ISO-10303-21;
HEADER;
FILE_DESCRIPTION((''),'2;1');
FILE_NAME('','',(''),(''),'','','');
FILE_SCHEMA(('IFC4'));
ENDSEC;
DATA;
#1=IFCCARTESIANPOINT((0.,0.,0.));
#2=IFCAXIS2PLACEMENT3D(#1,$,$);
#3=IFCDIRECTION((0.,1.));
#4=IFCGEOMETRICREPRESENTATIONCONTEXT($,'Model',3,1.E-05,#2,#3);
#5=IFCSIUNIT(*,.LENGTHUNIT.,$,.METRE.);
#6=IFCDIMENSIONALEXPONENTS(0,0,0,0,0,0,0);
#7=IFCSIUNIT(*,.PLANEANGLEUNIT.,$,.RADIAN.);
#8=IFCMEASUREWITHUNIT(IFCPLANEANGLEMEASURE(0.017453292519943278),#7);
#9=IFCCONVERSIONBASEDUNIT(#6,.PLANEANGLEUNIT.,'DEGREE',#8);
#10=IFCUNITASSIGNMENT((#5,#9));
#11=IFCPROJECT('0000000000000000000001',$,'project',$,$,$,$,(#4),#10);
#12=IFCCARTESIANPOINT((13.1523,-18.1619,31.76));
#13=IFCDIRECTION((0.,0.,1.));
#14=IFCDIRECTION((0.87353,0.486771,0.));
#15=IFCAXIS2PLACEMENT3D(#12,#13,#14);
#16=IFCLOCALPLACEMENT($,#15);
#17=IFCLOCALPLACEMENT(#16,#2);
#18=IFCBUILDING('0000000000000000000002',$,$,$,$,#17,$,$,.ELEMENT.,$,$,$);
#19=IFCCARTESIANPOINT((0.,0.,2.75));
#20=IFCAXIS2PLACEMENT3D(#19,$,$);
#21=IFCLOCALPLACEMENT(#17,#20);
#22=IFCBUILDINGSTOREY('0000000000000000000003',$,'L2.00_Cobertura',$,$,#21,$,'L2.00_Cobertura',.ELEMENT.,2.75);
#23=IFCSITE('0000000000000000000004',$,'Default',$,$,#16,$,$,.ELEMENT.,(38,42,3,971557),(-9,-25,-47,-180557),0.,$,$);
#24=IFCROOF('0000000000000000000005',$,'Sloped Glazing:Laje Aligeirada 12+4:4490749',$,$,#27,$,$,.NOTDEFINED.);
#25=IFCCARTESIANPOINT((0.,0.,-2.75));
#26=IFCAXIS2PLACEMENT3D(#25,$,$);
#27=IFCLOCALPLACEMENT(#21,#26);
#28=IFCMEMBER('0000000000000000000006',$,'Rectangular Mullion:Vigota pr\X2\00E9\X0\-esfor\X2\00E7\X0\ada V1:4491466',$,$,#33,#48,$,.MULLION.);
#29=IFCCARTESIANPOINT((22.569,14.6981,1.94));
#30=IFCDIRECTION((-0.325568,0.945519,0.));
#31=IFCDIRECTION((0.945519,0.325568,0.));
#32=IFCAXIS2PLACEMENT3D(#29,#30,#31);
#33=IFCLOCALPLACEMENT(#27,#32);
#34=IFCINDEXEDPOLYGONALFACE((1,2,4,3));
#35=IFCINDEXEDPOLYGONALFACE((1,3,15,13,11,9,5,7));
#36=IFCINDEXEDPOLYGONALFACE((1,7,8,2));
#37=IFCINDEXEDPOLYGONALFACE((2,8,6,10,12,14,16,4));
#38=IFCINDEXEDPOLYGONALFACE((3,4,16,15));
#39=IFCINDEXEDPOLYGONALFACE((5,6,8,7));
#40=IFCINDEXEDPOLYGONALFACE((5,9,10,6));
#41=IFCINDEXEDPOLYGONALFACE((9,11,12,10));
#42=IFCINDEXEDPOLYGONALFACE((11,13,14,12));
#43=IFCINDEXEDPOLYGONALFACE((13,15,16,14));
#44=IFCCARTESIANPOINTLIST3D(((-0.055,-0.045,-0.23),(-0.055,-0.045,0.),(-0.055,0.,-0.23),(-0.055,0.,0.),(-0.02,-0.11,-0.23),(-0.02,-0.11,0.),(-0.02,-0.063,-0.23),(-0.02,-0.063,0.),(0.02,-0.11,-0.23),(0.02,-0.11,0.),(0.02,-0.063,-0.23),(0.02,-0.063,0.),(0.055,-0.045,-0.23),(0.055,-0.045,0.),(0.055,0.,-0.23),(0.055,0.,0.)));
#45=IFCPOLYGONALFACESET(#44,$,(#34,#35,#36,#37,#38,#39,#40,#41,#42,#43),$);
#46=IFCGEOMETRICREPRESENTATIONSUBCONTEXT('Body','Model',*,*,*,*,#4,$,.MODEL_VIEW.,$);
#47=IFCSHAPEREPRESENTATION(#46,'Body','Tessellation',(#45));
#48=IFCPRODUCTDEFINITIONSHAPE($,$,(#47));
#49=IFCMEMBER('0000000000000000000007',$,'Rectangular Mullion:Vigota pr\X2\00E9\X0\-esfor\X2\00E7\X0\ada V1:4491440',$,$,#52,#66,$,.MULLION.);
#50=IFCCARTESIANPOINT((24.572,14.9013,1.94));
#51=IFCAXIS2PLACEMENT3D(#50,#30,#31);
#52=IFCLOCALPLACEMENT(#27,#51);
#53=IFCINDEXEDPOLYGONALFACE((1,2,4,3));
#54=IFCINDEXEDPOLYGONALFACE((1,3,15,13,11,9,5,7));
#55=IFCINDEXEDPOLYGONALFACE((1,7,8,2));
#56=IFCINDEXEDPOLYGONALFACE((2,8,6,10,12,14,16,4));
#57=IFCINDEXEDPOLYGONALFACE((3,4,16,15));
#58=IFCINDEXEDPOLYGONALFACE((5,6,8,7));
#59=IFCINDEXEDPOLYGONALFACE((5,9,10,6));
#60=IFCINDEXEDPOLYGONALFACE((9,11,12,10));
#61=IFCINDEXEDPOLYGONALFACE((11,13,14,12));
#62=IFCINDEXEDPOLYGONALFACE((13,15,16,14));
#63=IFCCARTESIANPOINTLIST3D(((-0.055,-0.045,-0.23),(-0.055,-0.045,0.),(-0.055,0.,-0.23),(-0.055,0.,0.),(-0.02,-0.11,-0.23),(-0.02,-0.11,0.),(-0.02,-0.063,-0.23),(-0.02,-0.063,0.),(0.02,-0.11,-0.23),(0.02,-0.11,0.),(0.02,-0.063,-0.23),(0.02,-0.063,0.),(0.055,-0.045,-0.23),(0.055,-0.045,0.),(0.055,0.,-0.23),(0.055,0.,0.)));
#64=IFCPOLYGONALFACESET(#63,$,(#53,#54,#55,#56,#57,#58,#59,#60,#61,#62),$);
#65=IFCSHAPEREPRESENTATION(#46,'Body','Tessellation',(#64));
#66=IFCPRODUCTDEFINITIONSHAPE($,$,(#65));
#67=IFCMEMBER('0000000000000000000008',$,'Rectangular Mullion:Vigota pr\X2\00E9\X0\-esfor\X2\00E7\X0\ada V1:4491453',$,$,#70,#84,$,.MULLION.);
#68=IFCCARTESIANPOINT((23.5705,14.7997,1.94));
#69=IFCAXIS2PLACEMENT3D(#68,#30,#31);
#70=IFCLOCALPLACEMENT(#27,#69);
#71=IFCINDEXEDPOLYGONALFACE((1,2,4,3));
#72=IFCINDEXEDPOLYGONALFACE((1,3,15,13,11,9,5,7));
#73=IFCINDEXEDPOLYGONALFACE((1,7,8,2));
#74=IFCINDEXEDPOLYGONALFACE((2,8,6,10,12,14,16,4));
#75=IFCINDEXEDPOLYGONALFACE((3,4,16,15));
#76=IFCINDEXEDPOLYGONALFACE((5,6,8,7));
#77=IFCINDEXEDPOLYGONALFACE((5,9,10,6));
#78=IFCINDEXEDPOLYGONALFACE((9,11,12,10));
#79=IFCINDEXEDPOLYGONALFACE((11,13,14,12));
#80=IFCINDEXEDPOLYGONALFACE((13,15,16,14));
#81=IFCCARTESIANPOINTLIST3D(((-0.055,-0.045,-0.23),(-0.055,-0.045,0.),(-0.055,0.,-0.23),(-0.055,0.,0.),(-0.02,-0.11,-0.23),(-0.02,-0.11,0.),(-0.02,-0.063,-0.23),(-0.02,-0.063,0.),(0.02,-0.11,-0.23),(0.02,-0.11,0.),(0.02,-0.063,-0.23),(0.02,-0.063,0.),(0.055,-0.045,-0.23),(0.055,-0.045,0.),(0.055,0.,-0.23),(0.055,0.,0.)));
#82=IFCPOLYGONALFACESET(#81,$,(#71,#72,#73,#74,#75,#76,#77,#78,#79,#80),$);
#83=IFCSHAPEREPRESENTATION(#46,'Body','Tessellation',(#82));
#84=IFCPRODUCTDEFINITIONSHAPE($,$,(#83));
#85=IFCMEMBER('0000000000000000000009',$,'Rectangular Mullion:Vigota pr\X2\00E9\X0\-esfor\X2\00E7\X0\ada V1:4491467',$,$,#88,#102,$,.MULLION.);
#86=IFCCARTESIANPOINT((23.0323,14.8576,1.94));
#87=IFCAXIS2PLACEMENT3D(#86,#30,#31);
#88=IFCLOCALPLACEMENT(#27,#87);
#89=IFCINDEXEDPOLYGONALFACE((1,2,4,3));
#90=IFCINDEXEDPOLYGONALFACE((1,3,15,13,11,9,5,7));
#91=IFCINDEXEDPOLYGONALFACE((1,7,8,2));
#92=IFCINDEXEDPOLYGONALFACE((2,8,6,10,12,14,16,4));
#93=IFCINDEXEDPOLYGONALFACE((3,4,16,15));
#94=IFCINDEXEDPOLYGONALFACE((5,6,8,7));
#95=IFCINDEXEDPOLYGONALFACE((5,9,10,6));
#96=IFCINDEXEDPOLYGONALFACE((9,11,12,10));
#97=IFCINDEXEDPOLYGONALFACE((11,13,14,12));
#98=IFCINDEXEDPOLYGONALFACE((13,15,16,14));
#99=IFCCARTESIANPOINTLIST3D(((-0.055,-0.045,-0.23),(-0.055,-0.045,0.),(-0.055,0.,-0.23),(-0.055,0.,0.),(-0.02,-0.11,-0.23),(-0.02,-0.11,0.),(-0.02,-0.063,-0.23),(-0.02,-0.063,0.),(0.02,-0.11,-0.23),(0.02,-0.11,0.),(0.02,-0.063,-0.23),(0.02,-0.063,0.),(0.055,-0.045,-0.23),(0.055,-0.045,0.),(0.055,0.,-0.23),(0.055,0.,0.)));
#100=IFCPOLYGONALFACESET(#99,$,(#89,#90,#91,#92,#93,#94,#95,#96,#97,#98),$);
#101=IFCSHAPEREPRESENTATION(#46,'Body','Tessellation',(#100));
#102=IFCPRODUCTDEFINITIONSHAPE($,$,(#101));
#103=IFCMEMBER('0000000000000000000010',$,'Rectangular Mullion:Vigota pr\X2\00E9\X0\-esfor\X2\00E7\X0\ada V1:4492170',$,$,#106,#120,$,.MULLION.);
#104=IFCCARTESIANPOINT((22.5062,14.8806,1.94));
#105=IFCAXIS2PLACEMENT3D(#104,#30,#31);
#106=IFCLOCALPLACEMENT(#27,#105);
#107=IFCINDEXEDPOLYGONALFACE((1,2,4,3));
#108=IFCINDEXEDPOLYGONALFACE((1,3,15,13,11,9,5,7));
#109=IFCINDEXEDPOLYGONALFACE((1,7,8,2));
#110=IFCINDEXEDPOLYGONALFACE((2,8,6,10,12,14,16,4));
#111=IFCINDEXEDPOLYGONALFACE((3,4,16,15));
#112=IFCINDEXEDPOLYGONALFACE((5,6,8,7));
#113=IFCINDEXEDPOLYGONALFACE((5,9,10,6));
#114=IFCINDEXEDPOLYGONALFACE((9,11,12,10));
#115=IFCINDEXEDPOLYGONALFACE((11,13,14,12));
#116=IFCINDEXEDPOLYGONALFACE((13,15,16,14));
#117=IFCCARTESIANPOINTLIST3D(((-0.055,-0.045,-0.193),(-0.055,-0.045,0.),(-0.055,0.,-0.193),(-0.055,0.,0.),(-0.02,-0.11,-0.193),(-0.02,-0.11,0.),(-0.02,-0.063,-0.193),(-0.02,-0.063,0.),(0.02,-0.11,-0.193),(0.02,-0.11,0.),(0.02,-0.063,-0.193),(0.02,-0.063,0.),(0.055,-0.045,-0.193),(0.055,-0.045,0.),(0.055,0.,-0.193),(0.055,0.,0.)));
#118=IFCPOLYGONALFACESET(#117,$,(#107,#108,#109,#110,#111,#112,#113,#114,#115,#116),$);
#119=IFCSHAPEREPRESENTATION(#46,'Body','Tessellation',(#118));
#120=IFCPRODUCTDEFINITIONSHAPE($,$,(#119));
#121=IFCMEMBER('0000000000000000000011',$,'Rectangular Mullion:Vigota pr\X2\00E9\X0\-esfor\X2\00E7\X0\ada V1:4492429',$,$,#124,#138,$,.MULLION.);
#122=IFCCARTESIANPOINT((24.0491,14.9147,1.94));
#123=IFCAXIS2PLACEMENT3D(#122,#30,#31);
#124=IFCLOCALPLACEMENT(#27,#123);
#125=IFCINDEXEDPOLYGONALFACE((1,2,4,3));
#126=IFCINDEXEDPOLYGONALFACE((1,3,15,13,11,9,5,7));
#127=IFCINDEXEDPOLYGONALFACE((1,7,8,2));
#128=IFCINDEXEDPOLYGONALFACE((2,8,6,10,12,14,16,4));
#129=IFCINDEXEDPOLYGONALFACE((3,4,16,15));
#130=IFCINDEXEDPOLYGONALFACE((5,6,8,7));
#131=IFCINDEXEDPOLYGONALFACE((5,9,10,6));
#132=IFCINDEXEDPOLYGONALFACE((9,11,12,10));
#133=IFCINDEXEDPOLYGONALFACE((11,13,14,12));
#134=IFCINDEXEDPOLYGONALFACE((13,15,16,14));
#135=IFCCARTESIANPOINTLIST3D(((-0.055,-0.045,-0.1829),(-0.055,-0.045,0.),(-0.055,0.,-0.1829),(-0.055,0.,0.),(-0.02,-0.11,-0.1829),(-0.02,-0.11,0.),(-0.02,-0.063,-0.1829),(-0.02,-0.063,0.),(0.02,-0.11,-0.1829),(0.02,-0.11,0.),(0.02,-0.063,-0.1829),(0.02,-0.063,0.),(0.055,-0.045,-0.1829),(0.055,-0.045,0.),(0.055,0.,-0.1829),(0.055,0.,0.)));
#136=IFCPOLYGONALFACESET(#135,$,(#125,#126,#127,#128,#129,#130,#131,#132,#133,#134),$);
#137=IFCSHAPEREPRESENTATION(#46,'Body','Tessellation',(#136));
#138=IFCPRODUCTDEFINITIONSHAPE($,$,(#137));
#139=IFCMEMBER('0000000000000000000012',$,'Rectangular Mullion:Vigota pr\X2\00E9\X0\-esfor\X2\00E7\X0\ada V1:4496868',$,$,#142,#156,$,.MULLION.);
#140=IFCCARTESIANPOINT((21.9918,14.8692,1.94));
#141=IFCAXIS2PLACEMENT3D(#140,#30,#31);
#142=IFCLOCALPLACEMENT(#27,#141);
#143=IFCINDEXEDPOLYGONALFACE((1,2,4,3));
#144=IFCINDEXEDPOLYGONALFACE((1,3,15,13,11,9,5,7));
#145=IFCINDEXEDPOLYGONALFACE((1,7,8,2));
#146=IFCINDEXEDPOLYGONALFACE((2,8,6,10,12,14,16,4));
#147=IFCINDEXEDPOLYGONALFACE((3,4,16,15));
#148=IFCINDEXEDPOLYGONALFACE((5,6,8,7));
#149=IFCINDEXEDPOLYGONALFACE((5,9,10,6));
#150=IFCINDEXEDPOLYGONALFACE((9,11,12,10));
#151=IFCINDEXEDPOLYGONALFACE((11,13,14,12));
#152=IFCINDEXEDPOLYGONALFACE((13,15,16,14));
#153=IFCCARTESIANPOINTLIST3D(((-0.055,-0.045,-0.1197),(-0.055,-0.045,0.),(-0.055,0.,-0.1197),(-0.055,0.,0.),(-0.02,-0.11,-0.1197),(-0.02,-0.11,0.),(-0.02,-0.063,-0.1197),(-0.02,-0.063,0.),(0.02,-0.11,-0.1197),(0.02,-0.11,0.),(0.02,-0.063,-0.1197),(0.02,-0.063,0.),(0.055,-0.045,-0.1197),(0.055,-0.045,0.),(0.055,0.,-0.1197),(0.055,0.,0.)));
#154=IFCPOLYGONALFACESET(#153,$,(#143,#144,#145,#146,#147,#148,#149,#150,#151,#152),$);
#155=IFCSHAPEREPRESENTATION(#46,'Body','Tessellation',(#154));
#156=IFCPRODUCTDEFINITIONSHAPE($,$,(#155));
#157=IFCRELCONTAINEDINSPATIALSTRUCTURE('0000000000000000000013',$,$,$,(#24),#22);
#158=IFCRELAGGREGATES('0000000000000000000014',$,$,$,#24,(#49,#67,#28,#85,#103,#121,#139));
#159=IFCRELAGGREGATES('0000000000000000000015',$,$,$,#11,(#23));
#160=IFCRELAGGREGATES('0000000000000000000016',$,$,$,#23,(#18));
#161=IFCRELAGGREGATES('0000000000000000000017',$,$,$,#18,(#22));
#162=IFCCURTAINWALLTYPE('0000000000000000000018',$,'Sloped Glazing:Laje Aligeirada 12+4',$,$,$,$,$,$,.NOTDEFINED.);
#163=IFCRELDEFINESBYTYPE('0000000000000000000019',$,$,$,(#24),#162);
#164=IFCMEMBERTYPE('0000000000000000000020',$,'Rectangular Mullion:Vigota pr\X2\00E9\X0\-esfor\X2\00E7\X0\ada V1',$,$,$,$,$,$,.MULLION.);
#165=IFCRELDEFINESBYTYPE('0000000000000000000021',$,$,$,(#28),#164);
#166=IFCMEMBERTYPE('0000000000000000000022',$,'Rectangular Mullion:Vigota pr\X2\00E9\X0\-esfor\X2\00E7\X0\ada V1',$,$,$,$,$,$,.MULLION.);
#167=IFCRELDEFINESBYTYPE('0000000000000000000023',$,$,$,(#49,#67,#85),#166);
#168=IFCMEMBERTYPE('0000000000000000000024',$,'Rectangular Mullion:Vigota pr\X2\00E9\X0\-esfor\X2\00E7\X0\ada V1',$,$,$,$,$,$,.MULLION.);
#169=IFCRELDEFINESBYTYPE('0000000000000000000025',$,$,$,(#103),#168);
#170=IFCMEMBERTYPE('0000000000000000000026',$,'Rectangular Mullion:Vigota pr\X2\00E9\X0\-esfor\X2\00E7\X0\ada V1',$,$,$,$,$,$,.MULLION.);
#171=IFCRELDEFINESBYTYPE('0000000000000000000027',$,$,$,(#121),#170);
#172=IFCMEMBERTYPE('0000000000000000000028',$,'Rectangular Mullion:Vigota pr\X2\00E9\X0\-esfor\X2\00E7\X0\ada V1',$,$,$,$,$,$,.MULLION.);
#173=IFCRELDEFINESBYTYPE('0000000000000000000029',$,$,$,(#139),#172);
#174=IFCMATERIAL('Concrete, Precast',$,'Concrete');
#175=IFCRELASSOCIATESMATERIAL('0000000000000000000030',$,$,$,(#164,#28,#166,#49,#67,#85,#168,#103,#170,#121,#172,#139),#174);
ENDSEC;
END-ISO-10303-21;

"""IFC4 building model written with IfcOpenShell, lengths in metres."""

from ifc_helpers import new_model, entity, si_unit, converted_unit, direction, frame, origin, place, context, subcontext, project, spatial, indexed_curve, outline, extrude, source, transform, mapped, material, type_object, type_shapes, element, aggregate, save


model = new_model("IFC4")

# Units and contexts
model_context = context("Model", 3, precision=1e-05, world=origin(), true_north=direction((0.0, 1.0)))
body_context = subcontext(model_context, "Body", "Model", "MODEL_VIEW")
ifc_project = project(units=[si_unit("LENGTHUNIT", "METRE"), converted_unit("PLANEANGLEUNIT", "DEGREE", entity("IfcPlaneAngleMeasure", 0.017453292519943278), si_unit("PLANEANGLEUNIT", "RADIAN"), dimensions=[0, 0, 0, 0, 0, 0, 0])], contexts=[model_context])

# Site, building, storey
site_placement = place(None, frame((13.1523, -18.1619, 31.76), z_axis=(0.0, 0.0, 1.0), x_axis=(0.87353, 0.486771, 0.0)))
site = spatial("IfcSite", under=ifc_project, at=site_placement, Name="Default", CompositionType="ELEMENT", RefLatitude=(38, 42, 3, 971557), RefLongitude=(-9, -25, -47, -180557), RefElevation=0.0)
building_placement = place(site_placement, origin())
building = spatial("IfcBuilding", under=site, at=building_placement, CompositionType="ELEMENT")
storey_placement = place(building_placement, frame((0.0, 0.0, 2.75)))
storey = spatial("IfcBuildingStorey", under=building, at=storey_placement, Name="L2.00_Cobertura", LongName="L2.00_Cobertura", CompositionType="ELEMENT", Elevation=2.75)

# Roof, members
curtain_wall_type = type_object("IfcCurtainWallType", Name="Sloped Glazing:Laje Aligeirada 12+4", PredefinedType="NOTDEFINED")
roof_placement = place(storey_placement, frame((0.0, 0.0, -2.75)))
roof = element("IfcRoof", 1, at=roof_placement, inside=storey, type_object=curtain_wall_type, Name="Sloped Glazing:Laje Aligeirada 12+4:4490749", PredefinedType="NOTDEFINED")
ifc_material_1 = material(Name="Concrete, Precast", Category="Concrete")
member_type_1 = type_object("IfcMemberType", Name="Rectangular Mullion:Vigota pré-esforçada V1", PredefinedType="MULLION", material=ifc_material_1)
shared_shape_1 = source(origin(), body_context, "Body", "SweptSolid", [
    extrude(outline(indexed_curve([(-0.055, -0.0545), (0.055, -0.0545), (0.055, -0.0095), (0.02, 0.0085), (0.02, 0.0555), (-0.02, 0.0555), (-0.02, 0.0085), (-0.055, -0.0095), (-0.055, -0.0545)], self_intersect=False)), frame((0.0, -0.0545, -0.23), z_axis=(0.0, 0.0, 1.0), x_axis=(-1.0, 0.0, 0.0)), (0.0, 0.0, 1.0), 0.23),
])
type_shapes(member_type_1, [shared_shape_1])
member_1_placement = place(roof_placement, frame((22.569, 14.6981, 1.94), z_axis=(-0.325568, 0.945519, 0.0), x_axis=(0.945519, 0.325568, 0.0)))
member_1 = element("IfcMember", 2, at=member_1_placement, type_object=member_type_1, material=ifc_material_1, Name="Rectangular Mullion:Vigota pré-esforçada V1:4491466", PredefinedType="MULLION", context=body_context, shape_type="MappedRepresentation", body=[
    mapped(shared_shape_1, transform((0.0, 0.0, 0.0), scale=1.0)),
])
member_type_2 = type_object("IfcMemberType", Name="Rectangular Mullion:Vigota pré-esforçada V1", PredefinedType="MULLION", material=ifc_material_1)
shared_shape_2 = source(origin(), body_context, "Body", "SweptSolid", [
    extrude(outline(indexed_curve([(-0.055, -0.0545), (0.055, -0.0545), (0.055, -0.0095), (0.02, 0.0085), (0.02, 0.0555), (-0.02, 0.0555), (-0.02, 0.0085), (-0.055, -0.0095), (-0.055, -0.0545)], self_intersect=False)), frame((0.0, -0.0545, -0.23), z_axis=(0.0, 0.0, 1.0), x_axis=(-1.0, 0.0, 0.0)), (0.0, 0.0, 1.0), 0.23),
])
type_shapes(member_type_2, [shared_shape_2])
member_2_placement = place(roof_placement, frame((24.572, 14.9013, 1.94), z_axis=(-0.325568, 0.945519, 0.0), x_axis=(0.945519, 0.325568, 0.0)))
member_2 = element("IfcMember", 3, at=member_2_placement, type_object=member_type_2, material=ifc_material_1, Name="Rectangular Mullion:Vigota pré-esforçada V1:4491440", PredefinedType="MULLION", context=body_context, shape_type="MappedRepresentation", body=[
    mapped(shared_shape_2, transform((0.0, 0.0, 0.0), scale=1.0)),
])
member_3_placement = place(roof_placement, frame((23.5705, 14.7997, 1.94), z_axis=(-0.325568, 0.945519, 0.0), x_axis=(0.945519, 0.325568, 0.0)))
member_3 = element("IfcMember", 4, at=member_3_placement, type_object=member_type_2, material=ifc_material_1, Name="Rectangular Mullion:Vigota pré-esforçada V1:4491453", PredefinedType="MULLION", context=body_context, shape_type="MappedRepresentation", body=[
    mapped(shared_shape_2, transform((0.0, 0.0, 0.0), scale=1.0)),
])
member_4_placement = place(roof_placement, frame((23.0323, 14.8576, 1.94), z_axis=(-0.325568, 0.945519, 0.0), x_axis=(0.945519, 0.325568, 0.0)))
member_4 = element("IfcMember", 5, at=member_4_placement, type_object=member_type_2, material=ifc_material_1, Name="Rectangular Mullion:Vigota pré-esforçada V1:4491467", PredefinedType="MULLION", context=body_context, shape_type="MappedRepresentation", body=[
    mapped(shared_shape_2, transform((0.0, 0.0, 0.0), scale=1.0)),
])
member_type_3 = type_object("IfcMemberType", Name="Rectangular Mullion:Vigota pré-esforçada V1", PredefinedType="MULLION", material=ifc_material_1)
shared_shape_3 = source(origin(), body_context, "Body", "SweptSolid", [
    extrude(outline(indexed_curve([(-0.055, -0.0545), (0.055, -0.0545), (0.055, -0.0095), (0.02, 0.0085), (0.02, 0.0555), (-0.02, 0.0555), (-0.02, 0.0085), (-0.055, -0.0095), (-0.055, -0.0545)], self_intersect=False)), frame((0.0, -0.0545, -0.193), z_axis=(0.0, 0.0, 1.0), x_axis=(-1.0, 0.0, 0.0)), (0.0, 0.0, 1.0), 0.193),
])
type_shapes(member_type_3, [shared_shape_3])
member_5_placement = place(roof_placement, frame((22.5062, 14.8806, 1.94), z_axis=(-0.325568, 0.945519, 0.0), x_axis=(0.945519, 0.325568, 0.0)))
member_5 = element("IfcMember", 6, at=member_5_placement, type_object=member_type_3, material=ifc_material_1, Name="Rectangular Mullion:Vigota pré-esforçada V1:4492170", PredefinedType="MULLION", context=body_context, shape_type="MappedRepresentation", body=[
    mapped(shared_shape_3, transform((0.0, 0.0, 0.0), scale=1.0)),
])
member_type_4 = type_object("IfcMemberType", Name="Rectangular Mullion:Vigota pré-esforçada V1", PredefinedType="MULLION", material=ifc_material_1)
shared_shape_4 = source(origin(), body_context, "Body", "SweptSolid", [
    extrude(outline(indexed_curve([(-0.055, -0.0545), (0.055, -0.0545), (0.055, -0.0095), (0.02, 0.0085), (0.02, 0.0555), (-0.02, 0.0555), (-0.02, 0.0085), (-0.055, -0.0095), (-0.055, -0.0545)], self_intersect=False)), frame((0.0, -0.0545, -0.1829), z_axis=(0.0, 0.0, 1.0), x_axis=(-1.0, 0.0, 0.0)), (0.0, 0.0, 1.0), 0.1829),
])
type_shapes(member_type_4, [shared_shape_4])
member_6_placement = place(roof_placement, frame((24.0491, 14.9147, 1.94), z_axis=(-0.325568, 0.945519, 0.0), x_axis=(0.945519, 0.325568, 0.0)))
member_6 = element("IfcMember", 7, at=member_6_placement, type_object=member_type_4, material=ifc_material_1, Name="Rectangular Mullion:Vigota pré-esforçada V1:4492429", PredefinedType="MULLION", context=body_context, shape_type="MappedRepresentation", body=[
    mapped(shared_shape_4, transform((0.0, 0.0, 0.0), scale=1.0)),
])
member_type_5 = type_object("IfcMemberType", Name="Rectangular Mullion:Vigota pré-esforçada V1", PredefinedType="MULLION", material=ifc_material_1)
shared_shape_5 = source(origin(), body_context, "Body", "SweptSolid", [
    extrude(outline(indexed_curve([(-0.055, -0.0545), (0.055, -0.0545), (0.055, -0.0095), (0.02, 0.0085), (0.02, 0.0555), (-0.02, 0.0555), (-0.02, 0.0085), (-0.055, -0.0095), (-0.055, -0.0545)], self_intersect=False)), frame((0.0, -0.0545, -0.1197), z_axis=(0.0, 0.0, 1.0), x_axis=(-1.0, 0.0, 0.0)), (0.0, 0.0, 1.0), 0.1197),
])
type_shapes(member_type_5, [shared_shape_5])
member_7_placement = place(roof_placement, frame((21.9918, 14.8692, 1.94), z_axis=(-0.325568, 0.945519, 0.0), x_axis=(0.945519, 0.325568, 0.0)))
member_7 = element("IfcMember", 8, at=member_7_placement, type_object=member_type_5, material=ifc_material_1, Name="Rectangular Mullion:Vigota pré-esforçada V1:4496868", PredefinedType="MULLION", context=body_context, shape_type="MappedRepresentation", body=[
    mapped(shared_shape_5, transform((0.0, 0.0, 0.0), scale=1.0)),
])
aggregate(roof, [member_2, member_3, member_1, member_4, member_5, member_6, member_7])

save(model, "model.ifc")
